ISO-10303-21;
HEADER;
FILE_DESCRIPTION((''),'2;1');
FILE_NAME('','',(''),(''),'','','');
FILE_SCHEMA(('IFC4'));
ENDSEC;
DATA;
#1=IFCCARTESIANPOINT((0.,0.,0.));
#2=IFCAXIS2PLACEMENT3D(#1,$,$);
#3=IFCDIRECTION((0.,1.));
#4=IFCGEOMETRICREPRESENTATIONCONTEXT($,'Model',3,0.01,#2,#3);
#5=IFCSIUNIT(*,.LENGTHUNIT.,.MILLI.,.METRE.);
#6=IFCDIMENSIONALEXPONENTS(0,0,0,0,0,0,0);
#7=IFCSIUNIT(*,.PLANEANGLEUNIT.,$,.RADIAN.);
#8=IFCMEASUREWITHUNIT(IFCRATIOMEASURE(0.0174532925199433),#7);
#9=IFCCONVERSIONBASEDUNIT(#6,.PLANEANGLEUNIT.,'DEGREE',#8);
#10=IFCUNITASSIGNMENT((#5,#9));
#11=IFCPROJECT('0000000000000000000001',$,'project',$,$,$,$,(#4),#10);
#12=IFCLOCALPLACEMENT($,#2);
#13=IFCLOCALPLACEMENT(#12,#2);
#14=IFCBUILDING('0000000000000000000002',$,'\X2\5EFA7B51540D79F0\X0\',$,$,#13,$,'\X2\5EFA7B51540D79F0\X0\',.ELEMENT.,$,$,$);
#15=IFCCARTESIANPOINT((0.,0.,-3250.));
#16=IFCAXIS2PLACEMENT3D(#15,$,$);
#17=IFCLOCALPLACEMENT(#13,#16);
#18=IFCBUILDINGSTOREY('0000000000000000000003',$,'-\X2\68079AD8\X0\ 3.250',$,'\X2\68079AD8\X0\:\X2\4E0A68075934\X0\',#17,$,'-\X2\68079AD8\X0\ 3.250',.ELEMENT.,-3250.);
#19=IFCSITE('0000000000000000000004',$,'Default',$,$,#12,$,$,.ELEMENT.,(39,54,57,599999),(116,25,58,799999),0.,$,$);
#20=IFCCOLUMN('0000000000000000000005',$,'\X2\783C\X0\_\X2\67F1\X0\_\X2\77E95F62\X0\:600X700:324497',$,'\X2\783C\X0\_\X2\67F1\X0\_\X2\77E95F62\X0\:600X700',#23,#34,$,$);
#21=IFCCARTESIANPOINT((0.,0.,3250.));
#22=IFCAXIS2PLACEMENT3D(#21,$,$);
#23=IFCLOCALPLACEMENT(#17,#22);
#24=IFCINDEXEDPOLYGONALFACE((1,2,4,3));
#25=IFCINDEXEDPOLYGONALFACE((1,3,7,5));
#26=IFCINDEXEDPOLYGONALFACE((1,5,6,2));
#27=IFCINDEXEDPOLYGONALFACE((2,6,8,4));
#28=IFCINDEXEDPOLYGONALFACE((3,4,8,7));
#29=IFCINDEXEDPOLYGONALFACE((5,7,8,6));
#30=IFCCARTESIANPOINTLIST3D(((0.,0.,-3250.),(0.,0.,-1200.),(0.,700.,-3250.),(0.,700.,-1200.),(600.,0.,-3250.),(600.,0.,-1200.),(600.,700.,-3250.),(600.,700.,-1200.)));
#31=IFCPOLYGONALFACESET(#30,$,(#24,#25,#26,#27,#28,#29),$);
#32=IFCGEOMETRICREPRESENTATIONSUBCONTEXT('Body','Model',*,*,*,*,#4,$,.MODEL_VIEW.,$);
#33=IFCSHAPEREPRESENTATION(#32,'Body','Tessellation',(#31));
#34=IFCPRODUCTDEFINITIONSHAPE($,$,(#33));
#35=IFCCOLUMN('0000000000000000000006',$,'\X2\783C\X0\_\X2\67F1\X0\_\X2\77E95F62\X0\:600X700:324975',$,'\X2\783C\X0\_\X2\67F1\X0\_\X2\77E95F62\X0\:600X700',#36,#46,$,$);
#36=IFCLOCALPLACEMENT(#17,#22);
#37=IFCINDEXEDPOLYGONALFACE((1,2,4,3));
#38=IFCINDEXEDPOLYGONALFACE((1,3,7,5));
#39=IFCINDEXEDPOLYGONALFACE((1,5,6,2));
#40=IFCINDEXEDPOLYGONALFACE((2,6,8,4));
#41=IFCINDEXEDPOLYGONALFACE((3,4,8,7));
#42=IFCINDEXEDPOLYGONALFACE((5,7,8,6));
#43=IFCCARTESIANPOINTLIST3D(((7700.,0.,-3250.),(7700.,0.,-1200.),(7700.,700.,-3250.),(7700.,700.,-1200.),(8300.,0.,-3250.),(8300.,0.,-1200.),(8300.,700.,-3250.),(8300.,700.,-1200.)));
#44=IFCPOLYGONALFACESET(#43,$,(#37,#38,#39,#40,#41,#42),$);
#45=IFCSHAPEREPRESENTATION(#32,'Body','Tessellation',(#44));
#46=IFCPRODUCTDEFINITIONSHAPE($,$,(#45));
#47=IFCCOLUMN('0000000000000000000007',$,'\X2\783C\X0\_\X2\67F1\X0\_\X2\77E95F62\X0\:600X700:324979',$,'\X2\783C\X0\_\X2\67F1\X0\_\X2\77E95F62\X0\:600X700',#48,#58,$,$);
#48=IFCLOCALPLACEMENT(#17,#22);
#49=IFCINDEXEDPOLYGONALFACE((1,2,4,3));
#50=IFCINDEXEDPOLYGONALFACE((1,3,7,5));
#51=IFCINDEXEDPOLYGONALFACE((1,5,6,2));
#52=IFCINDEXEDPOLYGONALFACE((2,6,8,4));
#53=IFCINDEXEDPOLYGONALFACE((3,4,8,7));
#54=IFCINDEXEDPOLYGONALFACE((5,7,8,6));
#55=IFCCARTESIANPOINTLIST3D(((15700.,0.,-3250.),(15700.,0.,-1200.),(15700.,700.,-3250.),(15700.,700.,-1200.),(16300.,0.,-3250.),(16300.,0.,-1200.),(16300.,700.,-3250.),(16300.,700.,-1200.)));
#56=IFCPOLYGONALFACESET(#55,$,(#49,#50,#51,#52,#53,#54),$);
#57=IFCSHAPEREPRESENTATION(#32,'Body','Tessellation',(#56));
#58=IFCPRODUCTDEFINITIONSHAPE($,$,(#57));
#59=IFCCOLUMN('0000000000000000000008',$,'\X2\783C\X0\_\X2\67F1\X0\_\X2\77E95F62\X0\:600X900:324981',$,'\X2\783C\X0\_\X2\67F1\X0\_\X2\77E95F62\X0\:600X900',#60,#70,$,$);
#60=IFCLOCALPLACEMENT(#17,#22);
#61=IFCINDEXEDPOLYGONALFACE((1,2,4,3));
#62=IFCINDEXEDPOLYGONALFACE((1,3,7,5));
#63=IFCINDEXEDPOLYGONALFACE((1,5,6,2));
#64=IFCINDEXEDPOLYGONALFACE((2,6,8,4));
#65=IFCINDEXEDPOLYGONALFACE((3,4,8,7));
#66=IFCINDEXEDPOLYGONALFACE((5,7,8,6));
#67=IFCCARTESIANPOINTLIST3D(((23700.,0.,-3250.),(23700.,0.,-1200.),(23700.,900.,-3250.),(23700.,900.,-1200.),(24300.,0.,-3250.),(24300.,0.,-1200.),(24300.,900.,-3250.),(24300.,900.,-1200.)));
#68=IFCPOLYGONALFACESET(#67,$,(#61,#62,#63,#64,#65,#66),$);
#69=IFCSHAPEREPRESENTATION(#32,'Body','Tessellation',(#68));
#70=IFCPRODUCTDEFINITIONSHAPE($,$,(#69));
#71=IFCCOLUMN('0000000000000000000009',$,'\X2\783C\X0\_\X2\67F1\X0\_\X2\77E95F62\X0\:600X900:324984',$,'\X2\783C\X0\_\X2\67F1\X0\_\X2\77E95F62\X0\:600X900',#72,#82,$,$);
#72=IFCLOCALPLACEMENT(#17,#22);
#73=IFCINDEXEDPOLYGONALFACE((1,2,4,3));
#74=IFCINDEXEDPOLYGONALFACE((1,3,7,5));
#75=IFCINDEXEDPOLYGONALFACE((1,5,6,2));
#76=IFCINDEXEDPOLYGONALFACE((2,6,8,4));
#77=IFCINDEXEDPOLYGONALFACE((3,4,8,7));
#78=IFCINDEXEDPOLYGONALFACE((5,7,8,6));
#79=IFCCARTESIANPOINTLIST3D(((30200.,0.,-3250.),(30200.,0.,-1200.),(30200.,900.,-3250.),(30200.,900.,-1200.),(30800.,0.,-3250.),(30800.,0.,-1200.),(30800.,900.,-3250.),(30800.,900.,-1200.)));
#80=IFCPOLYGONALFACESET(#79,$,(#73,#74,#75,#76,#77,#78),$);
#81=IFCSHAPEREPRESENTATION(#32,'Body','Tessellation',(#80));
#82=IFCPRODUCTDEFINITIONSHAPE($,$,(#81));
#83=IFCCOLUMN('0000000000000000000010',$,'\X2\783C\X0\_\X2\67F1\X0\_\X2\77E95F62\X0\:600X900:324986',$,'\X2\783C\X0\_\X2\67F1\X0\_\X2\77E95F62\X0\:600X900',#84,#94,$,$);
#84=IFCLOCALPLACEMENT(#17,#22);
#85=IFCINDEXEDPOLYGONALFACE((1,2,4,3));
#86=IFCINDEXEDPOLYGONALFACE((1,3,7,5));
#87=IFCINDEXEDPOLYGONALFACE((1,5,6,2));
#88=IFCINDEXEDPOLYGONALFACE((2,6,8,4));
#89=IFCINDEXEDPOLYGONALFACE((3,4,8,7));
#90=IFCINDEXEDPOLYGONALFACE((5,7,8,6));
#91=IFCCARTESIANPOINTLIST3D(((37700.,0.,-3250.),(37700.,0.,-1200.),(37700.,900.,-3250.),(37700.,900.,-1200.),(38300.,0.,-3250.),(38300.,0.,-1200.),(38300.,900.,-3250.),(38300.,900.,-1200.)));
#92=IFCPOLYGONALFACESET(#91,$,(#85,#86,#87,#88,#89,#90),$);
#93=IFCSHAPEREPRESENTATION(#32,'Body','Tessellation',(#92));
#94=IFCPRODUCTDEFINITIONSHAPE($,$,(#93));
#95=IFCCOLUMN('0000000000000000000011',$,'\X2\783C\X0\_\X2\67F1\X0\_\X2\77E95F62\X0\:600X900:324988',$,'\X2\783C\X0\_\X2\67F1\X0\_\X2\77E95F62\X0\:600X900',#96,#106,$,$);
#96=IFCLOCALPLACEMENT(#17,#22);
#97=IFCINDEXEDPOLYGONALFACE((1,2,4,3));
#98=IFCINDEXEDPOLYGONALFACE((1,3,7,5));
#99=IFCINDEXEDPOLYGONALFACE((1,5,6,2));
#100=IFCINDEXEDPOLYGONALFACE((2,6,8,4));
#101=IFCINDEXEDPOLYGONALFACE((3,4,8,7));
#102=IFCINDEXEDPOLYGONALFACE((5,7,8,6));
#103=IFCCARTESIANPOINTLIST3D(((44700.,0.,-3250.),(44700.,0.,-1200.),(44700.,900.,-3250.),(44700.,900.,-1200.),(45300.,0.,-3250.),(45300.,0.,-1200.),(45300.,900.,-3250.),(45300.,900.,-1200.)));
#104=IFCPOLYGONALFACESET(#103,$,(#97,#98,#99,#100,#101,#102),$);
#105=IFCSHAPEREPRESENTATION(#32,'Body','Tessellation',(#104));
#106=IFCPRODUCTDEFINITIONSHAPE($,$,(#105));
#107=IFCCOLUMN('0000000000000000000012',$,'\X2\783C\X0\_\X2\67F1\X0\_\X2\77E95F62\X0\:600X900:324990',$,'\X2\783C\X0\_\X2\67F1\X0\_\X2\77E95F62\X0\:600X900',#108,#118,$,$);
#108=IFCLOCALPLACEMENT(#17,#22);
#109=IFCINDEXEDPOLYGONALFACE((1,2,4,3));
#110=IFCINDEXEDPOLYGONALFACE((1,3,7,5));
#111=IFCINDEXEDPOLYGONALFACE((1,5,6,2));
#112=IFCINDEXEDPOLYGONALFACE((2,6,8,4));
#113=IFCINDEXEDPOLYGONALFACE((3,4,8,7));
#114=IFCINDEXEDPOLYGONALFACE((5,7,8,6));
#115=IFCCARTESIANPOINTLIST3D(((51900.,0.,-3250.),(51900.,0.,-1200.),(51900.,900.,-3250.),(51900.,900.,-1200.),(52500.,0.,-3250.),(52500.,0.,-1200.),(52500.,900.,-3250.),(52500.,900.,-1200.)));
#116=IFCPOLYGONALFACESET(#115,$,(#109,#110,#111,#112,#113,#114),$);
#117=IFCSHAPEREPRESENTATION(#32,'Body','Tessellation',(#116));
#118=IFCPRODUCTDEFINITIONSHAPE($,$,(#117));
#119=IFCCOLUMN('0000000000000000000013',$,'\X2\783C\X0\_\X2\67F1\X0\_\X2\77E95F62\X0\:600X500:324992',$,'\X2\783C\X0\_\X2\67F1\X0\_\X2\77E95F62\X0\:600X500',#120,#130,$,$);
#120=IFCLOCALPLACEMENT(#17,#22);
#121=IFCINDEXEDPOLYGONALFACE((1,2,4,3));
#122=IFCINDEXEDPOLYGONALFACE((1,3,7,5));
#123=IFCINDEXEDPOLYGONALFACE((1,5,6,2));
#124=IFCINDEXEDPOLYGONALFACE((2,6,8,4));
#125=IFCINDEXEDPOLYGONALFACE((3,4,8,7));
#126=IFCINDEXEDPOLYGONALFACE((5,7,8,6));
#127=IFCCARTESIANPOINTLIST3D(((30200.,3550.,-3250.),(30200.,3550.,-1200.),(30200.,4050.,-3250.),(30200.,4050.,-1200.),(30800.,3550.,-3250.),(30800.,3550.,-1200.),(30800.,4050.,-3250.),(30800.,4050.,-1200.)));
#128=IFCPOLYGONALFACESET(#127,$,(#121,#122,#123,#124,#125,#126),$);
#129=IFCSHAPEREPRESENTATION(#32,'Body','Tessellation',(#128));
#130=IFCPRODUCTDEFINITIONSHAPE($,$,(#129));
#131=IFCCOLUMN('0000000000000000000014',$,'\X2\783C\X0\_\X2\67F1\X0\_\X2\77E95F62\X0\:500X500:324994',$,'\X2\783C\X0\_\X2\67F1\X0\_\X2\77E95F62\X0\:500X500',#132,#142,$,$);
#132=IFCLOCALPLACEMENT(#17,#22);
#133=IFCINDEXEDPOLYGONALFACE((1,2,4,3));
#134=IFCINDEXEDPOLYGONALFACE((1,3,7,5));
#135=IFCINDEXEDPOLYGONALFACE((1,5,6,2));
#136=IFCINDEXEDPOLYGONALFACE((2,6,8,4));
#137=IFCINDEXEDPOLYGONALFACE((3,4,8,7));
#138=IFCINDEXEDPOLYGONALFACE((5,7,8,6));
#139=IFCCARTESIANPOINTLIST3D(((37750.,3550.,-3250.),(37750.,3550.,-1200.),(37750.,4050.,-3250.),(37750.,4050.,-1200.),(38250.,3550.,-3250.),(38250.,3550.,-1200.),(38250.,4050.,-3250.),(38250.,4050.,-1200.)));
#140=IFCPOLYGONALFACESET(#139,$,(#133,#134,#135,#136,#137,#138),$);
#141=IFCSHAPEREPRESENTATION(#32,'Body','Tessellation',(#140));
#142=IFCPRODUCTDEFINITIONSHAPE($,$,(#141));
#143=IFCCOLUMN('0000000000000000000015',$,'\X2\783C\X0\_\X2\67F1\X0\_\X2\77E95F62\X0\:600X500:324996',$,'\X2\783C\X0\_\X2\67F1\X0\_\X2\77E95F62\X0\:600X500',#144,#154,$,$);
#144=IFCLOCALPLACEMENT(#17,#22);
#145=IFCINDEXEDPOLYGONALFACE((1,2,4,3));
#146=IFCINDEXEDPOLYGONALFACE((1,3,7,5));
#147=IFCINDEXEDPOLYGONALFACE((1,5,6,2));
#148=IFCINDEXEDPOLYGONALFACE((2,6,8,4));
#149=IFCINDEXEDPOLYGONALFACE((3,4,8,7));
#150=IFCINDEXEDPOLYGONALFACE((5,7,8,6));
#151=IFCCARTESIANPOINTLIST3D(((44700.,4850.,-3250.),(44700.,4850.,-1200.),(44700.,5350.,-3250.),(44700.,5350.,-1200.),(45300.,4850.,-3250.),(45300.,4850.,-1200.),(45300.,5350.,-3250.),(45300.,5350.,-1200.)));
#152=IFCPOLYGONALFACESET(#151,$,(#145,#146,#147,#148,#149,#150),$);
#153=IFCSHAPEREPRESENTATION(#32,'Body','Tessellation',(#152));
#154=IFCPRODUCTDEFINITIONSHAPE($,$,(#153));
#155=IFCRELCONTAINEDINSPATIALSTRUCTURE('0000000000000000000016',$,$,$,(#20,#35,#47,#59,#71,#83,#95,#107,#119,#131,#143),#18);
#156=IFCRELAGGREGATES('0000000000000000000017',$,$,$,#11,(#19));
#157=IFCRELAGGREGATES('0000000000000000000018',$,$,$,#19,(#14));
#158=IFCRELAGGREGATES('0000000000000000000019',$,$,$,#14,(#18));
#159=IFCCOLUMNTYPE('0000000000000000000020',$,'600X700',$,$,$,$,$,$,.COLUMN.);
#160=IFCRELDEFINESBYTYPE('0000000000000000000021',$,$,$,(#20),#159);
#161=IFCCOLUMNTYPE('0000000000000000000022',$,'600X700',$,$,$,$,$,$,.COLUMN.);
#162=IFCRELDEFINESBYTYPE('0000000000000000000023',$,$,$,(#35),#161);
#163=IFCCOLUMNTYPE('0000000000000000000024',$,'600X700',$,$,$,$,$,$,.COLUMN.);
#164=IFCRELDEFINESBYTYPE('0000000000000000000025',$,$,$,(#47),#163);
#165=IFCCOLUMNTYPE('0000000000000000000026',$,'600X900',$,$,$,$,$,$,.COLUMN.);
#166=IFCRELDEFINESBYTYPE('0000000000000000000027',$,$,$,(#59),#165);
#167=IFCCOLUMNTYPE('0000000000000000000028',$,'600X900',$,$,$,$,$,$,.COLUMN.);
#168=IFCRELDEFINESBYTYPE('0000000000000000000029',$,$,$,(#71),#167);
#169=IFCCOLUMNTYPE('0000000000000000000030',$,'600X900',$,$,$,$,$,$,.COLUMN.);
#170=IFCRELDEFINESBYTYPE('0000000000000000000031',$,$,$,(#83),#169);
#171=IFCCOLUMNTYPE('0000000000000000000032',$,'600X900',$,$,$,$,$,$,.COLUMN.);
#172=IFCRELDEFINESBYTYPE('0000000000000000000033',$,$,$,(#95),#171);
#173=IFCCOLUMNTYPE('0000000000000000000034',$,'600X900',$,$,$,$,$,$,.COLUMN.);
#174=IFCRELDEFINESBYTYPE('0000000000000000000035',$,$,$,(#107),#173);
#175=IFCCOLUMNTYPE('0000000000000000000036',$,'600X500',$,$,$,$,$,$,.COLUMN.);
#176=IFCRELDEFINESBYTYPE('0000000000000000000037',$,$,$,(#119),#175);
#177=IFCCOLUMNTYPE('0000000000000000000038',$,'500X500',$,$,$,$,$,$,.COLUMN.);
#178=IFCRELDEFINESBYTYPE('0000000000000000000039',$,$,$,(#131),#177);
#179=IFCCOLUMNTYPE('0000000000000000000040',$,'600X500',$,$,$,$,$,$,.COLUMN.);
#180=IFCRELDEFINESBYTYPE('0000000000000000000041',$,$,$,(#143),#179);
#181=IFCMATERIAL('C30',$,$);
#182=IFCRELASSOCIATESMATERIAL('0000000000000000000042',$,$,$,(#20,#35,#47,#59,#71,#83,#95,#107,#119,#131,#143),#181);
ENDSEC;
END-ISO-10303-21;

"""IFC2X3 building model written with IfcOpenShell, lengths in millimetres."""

from ifc_helpers import new_model, entity, si_unit, converted_unit, direction, frame, frame_2d, origin, origin_2d_with_axis, place, context, subcontext, project, spatial, rectangle, extrude, source, transform, mapped, material, type_object, type_shapes, element, save


model = new_model("IFC2X3")

# Units and contexts
model_context = context("Model", 3, precision=0.01, world=origin(), true_north=direction((0.0, 1.0)))
body_context = subcontext(model_context, "Body", "Model", "MODEL_VIEW")
ifc_project = project(units=[si_unit("LENGTHUNIT", "METRE", prefix="MILLI"), converted_unit("PLANEANGLEUNIT", "DEGREE", entity("IfcRatioMeasure", 0.0174532925199433), si_unit("PLANEANGLEUNIT", "RADIAN"), dimensions=[0, 0, 0, 0, 0, 0, 0])], contexts=[model_context])

# Site, building, storey
site_placement = place(None, origin())
site = spatial("IfcSite", under=ifc_project, at=site_placement, Name="Default", CompositionType="ELEMENT", RefLatitude=(39, 54, 57, 599999), RefLongitude=(116, 25, 58, 799999), RefElevation=0.0)
building_placement = place(site_placement, origin())
building = spatial("IfcBuilding", under=site, at=building_placement, Name="建筑名称", LongName="建筑名称", CompositionType="ELEMENT")
storey_placement = place(building_placement, frame((0.0, 0.0, -3250.0)))
storey = spatial("IfcBuildingStorey", under=building, at=storey_placement, Name="-标高 3.250", ObjectType="标高:上标头", LongName="-标高 3.250", CompositionType="ELEMENT", Elevation=-3250.0)

# Columns
ifc_material_1 = material(Name="C30")
column_type_1 = type_object("IfcColumnType", Name="600X700", PredefinedType="COLUMN")
shared_shape_1 = source(origin(), body_context, "Body", "SweptSolid", [
    extrude(rectangle(XDim=700.0, YDim=600.0, at=origin_2d_with_axis()), frame((300.0, 350.0, -3250.0), z_axis=(0.0, 0.0, 1.0), x_axis=(0.0, -1.0, 0.0)), (0.0, 0.0, 1.0), 2050.0),
])
type_shapes(column_type_1, [shared_shape_1])
column_1_placement = place(storey_placement, frame((0.0, 0.0, 3250.0)))
element("IfcColumn", 1, at=column_1_placement, inside=storey, type_object=column_type_1, material=ifc_material_1, Name="砼_柱_矩形:600X700:324497", ObjectType="砼_柱_矩形:600X700", context=body_context, shape_type="MappedRepresentation", body=[
    mapped(shared_shape_1, transform((0.0, 0.0, 0.0), scale=1.0)),
])
column_type_2 = type_object("IfcColumnType", Name="600X700", PredefinedType="COLUMN")
shared_shape_2 = source(origin(), body_context, "Body", "SweptSolid", [
    extrude(rectangle(XDim=700.0, YDim=600.0, at=origin_2d_with_axis()), frame((8000.0, 350.0, -3250.0), z_axis=(0.0, 0.0, 1.0), x_axis=(0.0, -1.0, 0.0)), (0.0, 0.0, 1.0), 2050.0),
])
type_shapes(column_type_2, [shared_shape_2])
column_2_placement = place(storey_placement, frame((0.0, 0.0, 3250.0)))
element("IfcColumn", 2, at=column_2_placement, inside=storey, type_object=column_type_2, material=ifc_material_1, Name="砼_柱_矩形:600X700:324975", ObjectType="砼_柱_矩形:600X700", context=body_context, shape_type="MappedRepresentation", body=[
    mapped(shared_shape_2, transform((0.0, 0.0, 0.0), scale=1.0)),
])
column_type_3 = type_object("IfcColumnType", Name="600X700", PredefinedType="COLUMN")
shared_shape_3 = source(origin(), body_context, "Body", "SweptSolid", [
    extrude(rectangle(XDim=700.0, YDim=600.0, at=frame_2d((0.0, 0.0), x_axis=(1.0, 0.0))), frame((16000.0, 350.0, -3250.0), z_axis=(0.0, 0.0, 1.0), x_axis=(0.0, -1.0, 0.0)), (0.0, 0.0, 1.0), 2050.0),
])
type_shapes(column_type_3, [shared_shape_3])
column_3_placement = place(storey_placement, frame((0.0, 0.0, 3250.0)))
element("IfcColumn", 3, at=column_3_placement, inside=storey, type_object=column_type_3, material=ifc_material_1, Name="砼_柱_矩形:600X700:324979", ObjectType="砼_柱_矩形:600X700", context=body_context, shape_type="MappedRepresentation", body=[
    mapped(shared_shape_3, transform((0.0, 0.0, 0.0), scale=1.0)),
])
column_type_4 = type_object("IfcColumnType", Name="600X900", PredefinedType="COLUMN")
shared_shape_4 = source(origin(), body_context, "Body", "SweptSolid", [
    extrude(rectangle(XDim=900.0, YDim=600.0, at=origin_2d_with_axis()), frame((24000.0, 450.0, -3250.0), z_axis=(0.0, 0.0, 1.0), x_axis=(0.0, -1.0, 0.0)), (0.0, 0.0, 1.0), 2050.0),
])
type_shapes(column_type_4, [shared_shape_4])
column_4_placement = place(storey_placement, frame((0.0, 0.0, 3250.0)))
element("IfcColumn", 4, at=column_4_placement, inside=storey, type_object=column_type_4, material=ifc_material_1, Name="砼_柱_矩形:600X900:324981", ObjectType="砼_柱_矩形:600X900", context=body_context, shape_type="MappedRepresentation", body=[
    mapped(shared_shape_4, transform((0.0, 0.0, 0.0), scale=1.0)),
])
column_type_5 = type_object("IfcColumnType", Name="600X900", PredefinedType="COLUMN")
shared_shape_5 = source(origin(), body_context, "Body", "SweptSolid", [
    extrude(rectangle(XDim=900.0, YDim=600.0, at=origin_2d_with_axis()), frame((30500.0, 450.0, -3250.0), z_axis=(0.0, 0.0, 1.0), x_axis=(0.0, -1.0, 0.0)), (0.0, 0.0, 1.0), 2050.0),
])
type_shapes(column_type_5, [shared_shape_5])
column_5_placement = place(storey_placement, frame((0.0, 0.0, 3250.0)))
element("IfcColumn", 5, at=column_5_placement, inside=storey, type_object=column_type_5, material=ifc_material_1, Name="砼_柱_矩形:600X900:324984", ObjectType="砼_柱_矩形:600X900", context=body_context, shape_type="MappedRepresentation", body=[
    mapped(shared_shape_5, transform((0.0, 0.0, 0.0), scale=1.0)),
])
column_type_6 = type_object("IfcColumnType", Name="600X900", PredefinedType="COLUMN")
shared_shape_6 = source(origin(), body_context, "Body", "SweptSolid", [
    extrude(rectangle(XDim=900.0, YDim=600.0, at=origin_2d_with_axis()), frame((38000.0, 450.0, -3250.0), z_axis=(0.0, 0.0, 1.0), x_axis=(0.0, -1.0, 0.0)), (0.0, 0.0, 1.0), 2050.0),
])
type_shapes(column_type_6, [shared_shape_6])
column_6_placement = place(storey_placement, frame((0.0, 0.0, 3250.0)))
element("IfcColumn", 6, at=column_6_placement, inside=storey, type_object=column_type_6, material=ifc_material_1, Name="砼_柱_矩形:600X900:324986", ObjectType="砼_柱_矩形:600X900", context=body_context, shape_type="MappedRepresentation", body=[
    mapped(shared_shape_6, transform((0.0, 0.0, 0.0), scale=1.0)),
])
column_type_7 = type_object("IfcColumnType", Name="600X900", PredefinedType="COLUMN")
shared_shape_7 = source(origin(), body_context, "Body", "SweptSolid", [
    extrude(rectangle(XDim=900.0, YDim=600.0, at=origin_2d_with_axis()), frame((45000.0, 450.0, -3250.0), z_axis=(0.0, 0.0, 1.0), x_axis=(0.0, -1.0, 0.0)), (0.0, 0.0, 1.0), 2050.0),
])
type_shapes(column_type_7, [shared_shape_7])
column_7_placement = place(storey_placement, frame((0.0, 0.0, 3250.0)))
element("IfcColumn", 7, at=column_7_placement, inside=storey, type_object=column_type_7, material=ifc_material_1, Name="砼_柱_矩形:600X900:324988", ObjectType="砼_柱_矩形:600X900", context=body_context, shape_type="MappedRepresentation", body=[
    mapped(shared_shape_7, transform((0.0, 0.0, 0.0), scale=1.0)),
])
column_type_8 = type_object("IfcColumnType", Name="600X900", PredefinedType="COLUMN")
shared_shape_8 = source(origin(), body_context, "Body", "SweptSolid", [
    extrude(rectangle(XDim=900.0, YDim=600.0, at=origin_2d_with_axis()), frame((52200.0, 450.0, -3250.0), z_axis=(0.0, 0.0, 1.0), x_axis=(0.0, -1.0, 0.0)), (0.0, 0.0, 1.0), 2050.0),
])
type_shapes(column_type_8, [shared_shape_8])
column_8_placement = place(storey_placement, frame((0.0, 0.0, 3250.0)))
element("IfcColumn", 8, at=column_8_placement, inside=storey, type_object=column_type_8, material=ifc_material_1, Name="砼_柱_矩形:600X900:324990", ObjectType="砼_柱_矩形:600X900", context=body_context, shape_type="MappedRepresentation", body=[
    mapped(shared_shape_8, transform((0.0, 0.0, 0.0), scale=1.0)),
])
column_type_9 = type_object("IfcColumnType", Name="600X500", PredefinedType="COLUMN")
shared_shape_9 = source(origin(), body_context, "Body", "SweptSolid", [
    extrude(rectangle(XDim=500.0, YDim=600.0, at=origin_2d_with_axis()), frame((30500.0, 3800.0, -3250.0), z_axis=(0.0, 0.0, 1.0), x_axis=(0.0, -1.0, 0.0)), (0.0, 0.0, 1.0), 2050.0),
])
type_shapes(column_type_9, [shared_shape_9])
column_9_placement = place(storey_placement, frame((0.0, 0.0, 3250.0)))
element("IfcColumn", 9, at=column_9_placement, inside=storey, type_object=column_type_9, material=ifc_material_1, Name="砼_柱_矩形:600X500:324992", ObjectType="砼_柱_矩形:600X500", context=body_context, shape_type="MappedRepresentation", body=[
    mapped(shared_shape_9, transform((0.0, 0.0, 0.0), scale=1.0)),
])
column_type_10 = type_object("IfcColumnType", Name="500X500", PredefinedType="COLUMN")
shared_shape_10 = source(origin(), body_context, "Body", "SweptSolid", [
    extrude(rectangle(XDim=500.0, YDim=500.0, at=origin_2d_with_axis()), frame((38000.0, 3800.0, -3250.0), z_axis=(0.0, 0.0, 1.0), x_axis=(0.0, -1.0, 0.0)), (0.0, 0.0, 1.0), 2050.0),
])
type_shapes(column_type_10, [shared_shape_10])
column_10_placement = place(storey_placement, frame((0.0, 0.0, 3250.0)))
element("IfcColumn", 10, at=column_10_placement, inside=storey, type_object=column_type_10, material=ifc_material_1, Name="砼_柱_矩形:500X500:324994", ObjectType="砼_柱_矩形:500X500", context=body_context, shape_type="MappedRepresentation", body=[
    mapped(shared_shape_10, transform((0.0, 0.0, 0.0), scale=1.0)),
])
column_type_11 = type_object("IfcColumnType", Name="600X500", PredefinedType="COLUMN")
shared_shape_11 = source(origin(), body_context, "Body", "SweptSolid", [
    extrude(rectangle(XDim=500.0, YDim=600.0, at=frame_2d((0.0, 0.0), x_axis=(1.0, 0.0))), frame((45000.0, 5100.0, -3250.0), z_axis=(0.0, 0.0, 1.0), x_axis=(0.0, -1.0, 0.0)), (0.0, 0.0, 1.0), 2050.0),
])
type_shapes(column_type_11, [shared_shape_11])
column_11_placement = place(storey_placement, frame((0.0, 0.0, 3250.0)))
element("IfcColumn", 11, at=column_11_placement, inside=storey, type_object=column_type_11, material=ifc_material_1, Name="砼_柱_矩形:600X500:324996", ObjectType="砼_柱_矩形:600X500", context=body_context, shape_type="MappedRepresentation", body=[
    mapped(shared_shape_11, transform((0.0, 0.0, 0.0), scale=1.0)),
])

save(model, "model.ifc")
